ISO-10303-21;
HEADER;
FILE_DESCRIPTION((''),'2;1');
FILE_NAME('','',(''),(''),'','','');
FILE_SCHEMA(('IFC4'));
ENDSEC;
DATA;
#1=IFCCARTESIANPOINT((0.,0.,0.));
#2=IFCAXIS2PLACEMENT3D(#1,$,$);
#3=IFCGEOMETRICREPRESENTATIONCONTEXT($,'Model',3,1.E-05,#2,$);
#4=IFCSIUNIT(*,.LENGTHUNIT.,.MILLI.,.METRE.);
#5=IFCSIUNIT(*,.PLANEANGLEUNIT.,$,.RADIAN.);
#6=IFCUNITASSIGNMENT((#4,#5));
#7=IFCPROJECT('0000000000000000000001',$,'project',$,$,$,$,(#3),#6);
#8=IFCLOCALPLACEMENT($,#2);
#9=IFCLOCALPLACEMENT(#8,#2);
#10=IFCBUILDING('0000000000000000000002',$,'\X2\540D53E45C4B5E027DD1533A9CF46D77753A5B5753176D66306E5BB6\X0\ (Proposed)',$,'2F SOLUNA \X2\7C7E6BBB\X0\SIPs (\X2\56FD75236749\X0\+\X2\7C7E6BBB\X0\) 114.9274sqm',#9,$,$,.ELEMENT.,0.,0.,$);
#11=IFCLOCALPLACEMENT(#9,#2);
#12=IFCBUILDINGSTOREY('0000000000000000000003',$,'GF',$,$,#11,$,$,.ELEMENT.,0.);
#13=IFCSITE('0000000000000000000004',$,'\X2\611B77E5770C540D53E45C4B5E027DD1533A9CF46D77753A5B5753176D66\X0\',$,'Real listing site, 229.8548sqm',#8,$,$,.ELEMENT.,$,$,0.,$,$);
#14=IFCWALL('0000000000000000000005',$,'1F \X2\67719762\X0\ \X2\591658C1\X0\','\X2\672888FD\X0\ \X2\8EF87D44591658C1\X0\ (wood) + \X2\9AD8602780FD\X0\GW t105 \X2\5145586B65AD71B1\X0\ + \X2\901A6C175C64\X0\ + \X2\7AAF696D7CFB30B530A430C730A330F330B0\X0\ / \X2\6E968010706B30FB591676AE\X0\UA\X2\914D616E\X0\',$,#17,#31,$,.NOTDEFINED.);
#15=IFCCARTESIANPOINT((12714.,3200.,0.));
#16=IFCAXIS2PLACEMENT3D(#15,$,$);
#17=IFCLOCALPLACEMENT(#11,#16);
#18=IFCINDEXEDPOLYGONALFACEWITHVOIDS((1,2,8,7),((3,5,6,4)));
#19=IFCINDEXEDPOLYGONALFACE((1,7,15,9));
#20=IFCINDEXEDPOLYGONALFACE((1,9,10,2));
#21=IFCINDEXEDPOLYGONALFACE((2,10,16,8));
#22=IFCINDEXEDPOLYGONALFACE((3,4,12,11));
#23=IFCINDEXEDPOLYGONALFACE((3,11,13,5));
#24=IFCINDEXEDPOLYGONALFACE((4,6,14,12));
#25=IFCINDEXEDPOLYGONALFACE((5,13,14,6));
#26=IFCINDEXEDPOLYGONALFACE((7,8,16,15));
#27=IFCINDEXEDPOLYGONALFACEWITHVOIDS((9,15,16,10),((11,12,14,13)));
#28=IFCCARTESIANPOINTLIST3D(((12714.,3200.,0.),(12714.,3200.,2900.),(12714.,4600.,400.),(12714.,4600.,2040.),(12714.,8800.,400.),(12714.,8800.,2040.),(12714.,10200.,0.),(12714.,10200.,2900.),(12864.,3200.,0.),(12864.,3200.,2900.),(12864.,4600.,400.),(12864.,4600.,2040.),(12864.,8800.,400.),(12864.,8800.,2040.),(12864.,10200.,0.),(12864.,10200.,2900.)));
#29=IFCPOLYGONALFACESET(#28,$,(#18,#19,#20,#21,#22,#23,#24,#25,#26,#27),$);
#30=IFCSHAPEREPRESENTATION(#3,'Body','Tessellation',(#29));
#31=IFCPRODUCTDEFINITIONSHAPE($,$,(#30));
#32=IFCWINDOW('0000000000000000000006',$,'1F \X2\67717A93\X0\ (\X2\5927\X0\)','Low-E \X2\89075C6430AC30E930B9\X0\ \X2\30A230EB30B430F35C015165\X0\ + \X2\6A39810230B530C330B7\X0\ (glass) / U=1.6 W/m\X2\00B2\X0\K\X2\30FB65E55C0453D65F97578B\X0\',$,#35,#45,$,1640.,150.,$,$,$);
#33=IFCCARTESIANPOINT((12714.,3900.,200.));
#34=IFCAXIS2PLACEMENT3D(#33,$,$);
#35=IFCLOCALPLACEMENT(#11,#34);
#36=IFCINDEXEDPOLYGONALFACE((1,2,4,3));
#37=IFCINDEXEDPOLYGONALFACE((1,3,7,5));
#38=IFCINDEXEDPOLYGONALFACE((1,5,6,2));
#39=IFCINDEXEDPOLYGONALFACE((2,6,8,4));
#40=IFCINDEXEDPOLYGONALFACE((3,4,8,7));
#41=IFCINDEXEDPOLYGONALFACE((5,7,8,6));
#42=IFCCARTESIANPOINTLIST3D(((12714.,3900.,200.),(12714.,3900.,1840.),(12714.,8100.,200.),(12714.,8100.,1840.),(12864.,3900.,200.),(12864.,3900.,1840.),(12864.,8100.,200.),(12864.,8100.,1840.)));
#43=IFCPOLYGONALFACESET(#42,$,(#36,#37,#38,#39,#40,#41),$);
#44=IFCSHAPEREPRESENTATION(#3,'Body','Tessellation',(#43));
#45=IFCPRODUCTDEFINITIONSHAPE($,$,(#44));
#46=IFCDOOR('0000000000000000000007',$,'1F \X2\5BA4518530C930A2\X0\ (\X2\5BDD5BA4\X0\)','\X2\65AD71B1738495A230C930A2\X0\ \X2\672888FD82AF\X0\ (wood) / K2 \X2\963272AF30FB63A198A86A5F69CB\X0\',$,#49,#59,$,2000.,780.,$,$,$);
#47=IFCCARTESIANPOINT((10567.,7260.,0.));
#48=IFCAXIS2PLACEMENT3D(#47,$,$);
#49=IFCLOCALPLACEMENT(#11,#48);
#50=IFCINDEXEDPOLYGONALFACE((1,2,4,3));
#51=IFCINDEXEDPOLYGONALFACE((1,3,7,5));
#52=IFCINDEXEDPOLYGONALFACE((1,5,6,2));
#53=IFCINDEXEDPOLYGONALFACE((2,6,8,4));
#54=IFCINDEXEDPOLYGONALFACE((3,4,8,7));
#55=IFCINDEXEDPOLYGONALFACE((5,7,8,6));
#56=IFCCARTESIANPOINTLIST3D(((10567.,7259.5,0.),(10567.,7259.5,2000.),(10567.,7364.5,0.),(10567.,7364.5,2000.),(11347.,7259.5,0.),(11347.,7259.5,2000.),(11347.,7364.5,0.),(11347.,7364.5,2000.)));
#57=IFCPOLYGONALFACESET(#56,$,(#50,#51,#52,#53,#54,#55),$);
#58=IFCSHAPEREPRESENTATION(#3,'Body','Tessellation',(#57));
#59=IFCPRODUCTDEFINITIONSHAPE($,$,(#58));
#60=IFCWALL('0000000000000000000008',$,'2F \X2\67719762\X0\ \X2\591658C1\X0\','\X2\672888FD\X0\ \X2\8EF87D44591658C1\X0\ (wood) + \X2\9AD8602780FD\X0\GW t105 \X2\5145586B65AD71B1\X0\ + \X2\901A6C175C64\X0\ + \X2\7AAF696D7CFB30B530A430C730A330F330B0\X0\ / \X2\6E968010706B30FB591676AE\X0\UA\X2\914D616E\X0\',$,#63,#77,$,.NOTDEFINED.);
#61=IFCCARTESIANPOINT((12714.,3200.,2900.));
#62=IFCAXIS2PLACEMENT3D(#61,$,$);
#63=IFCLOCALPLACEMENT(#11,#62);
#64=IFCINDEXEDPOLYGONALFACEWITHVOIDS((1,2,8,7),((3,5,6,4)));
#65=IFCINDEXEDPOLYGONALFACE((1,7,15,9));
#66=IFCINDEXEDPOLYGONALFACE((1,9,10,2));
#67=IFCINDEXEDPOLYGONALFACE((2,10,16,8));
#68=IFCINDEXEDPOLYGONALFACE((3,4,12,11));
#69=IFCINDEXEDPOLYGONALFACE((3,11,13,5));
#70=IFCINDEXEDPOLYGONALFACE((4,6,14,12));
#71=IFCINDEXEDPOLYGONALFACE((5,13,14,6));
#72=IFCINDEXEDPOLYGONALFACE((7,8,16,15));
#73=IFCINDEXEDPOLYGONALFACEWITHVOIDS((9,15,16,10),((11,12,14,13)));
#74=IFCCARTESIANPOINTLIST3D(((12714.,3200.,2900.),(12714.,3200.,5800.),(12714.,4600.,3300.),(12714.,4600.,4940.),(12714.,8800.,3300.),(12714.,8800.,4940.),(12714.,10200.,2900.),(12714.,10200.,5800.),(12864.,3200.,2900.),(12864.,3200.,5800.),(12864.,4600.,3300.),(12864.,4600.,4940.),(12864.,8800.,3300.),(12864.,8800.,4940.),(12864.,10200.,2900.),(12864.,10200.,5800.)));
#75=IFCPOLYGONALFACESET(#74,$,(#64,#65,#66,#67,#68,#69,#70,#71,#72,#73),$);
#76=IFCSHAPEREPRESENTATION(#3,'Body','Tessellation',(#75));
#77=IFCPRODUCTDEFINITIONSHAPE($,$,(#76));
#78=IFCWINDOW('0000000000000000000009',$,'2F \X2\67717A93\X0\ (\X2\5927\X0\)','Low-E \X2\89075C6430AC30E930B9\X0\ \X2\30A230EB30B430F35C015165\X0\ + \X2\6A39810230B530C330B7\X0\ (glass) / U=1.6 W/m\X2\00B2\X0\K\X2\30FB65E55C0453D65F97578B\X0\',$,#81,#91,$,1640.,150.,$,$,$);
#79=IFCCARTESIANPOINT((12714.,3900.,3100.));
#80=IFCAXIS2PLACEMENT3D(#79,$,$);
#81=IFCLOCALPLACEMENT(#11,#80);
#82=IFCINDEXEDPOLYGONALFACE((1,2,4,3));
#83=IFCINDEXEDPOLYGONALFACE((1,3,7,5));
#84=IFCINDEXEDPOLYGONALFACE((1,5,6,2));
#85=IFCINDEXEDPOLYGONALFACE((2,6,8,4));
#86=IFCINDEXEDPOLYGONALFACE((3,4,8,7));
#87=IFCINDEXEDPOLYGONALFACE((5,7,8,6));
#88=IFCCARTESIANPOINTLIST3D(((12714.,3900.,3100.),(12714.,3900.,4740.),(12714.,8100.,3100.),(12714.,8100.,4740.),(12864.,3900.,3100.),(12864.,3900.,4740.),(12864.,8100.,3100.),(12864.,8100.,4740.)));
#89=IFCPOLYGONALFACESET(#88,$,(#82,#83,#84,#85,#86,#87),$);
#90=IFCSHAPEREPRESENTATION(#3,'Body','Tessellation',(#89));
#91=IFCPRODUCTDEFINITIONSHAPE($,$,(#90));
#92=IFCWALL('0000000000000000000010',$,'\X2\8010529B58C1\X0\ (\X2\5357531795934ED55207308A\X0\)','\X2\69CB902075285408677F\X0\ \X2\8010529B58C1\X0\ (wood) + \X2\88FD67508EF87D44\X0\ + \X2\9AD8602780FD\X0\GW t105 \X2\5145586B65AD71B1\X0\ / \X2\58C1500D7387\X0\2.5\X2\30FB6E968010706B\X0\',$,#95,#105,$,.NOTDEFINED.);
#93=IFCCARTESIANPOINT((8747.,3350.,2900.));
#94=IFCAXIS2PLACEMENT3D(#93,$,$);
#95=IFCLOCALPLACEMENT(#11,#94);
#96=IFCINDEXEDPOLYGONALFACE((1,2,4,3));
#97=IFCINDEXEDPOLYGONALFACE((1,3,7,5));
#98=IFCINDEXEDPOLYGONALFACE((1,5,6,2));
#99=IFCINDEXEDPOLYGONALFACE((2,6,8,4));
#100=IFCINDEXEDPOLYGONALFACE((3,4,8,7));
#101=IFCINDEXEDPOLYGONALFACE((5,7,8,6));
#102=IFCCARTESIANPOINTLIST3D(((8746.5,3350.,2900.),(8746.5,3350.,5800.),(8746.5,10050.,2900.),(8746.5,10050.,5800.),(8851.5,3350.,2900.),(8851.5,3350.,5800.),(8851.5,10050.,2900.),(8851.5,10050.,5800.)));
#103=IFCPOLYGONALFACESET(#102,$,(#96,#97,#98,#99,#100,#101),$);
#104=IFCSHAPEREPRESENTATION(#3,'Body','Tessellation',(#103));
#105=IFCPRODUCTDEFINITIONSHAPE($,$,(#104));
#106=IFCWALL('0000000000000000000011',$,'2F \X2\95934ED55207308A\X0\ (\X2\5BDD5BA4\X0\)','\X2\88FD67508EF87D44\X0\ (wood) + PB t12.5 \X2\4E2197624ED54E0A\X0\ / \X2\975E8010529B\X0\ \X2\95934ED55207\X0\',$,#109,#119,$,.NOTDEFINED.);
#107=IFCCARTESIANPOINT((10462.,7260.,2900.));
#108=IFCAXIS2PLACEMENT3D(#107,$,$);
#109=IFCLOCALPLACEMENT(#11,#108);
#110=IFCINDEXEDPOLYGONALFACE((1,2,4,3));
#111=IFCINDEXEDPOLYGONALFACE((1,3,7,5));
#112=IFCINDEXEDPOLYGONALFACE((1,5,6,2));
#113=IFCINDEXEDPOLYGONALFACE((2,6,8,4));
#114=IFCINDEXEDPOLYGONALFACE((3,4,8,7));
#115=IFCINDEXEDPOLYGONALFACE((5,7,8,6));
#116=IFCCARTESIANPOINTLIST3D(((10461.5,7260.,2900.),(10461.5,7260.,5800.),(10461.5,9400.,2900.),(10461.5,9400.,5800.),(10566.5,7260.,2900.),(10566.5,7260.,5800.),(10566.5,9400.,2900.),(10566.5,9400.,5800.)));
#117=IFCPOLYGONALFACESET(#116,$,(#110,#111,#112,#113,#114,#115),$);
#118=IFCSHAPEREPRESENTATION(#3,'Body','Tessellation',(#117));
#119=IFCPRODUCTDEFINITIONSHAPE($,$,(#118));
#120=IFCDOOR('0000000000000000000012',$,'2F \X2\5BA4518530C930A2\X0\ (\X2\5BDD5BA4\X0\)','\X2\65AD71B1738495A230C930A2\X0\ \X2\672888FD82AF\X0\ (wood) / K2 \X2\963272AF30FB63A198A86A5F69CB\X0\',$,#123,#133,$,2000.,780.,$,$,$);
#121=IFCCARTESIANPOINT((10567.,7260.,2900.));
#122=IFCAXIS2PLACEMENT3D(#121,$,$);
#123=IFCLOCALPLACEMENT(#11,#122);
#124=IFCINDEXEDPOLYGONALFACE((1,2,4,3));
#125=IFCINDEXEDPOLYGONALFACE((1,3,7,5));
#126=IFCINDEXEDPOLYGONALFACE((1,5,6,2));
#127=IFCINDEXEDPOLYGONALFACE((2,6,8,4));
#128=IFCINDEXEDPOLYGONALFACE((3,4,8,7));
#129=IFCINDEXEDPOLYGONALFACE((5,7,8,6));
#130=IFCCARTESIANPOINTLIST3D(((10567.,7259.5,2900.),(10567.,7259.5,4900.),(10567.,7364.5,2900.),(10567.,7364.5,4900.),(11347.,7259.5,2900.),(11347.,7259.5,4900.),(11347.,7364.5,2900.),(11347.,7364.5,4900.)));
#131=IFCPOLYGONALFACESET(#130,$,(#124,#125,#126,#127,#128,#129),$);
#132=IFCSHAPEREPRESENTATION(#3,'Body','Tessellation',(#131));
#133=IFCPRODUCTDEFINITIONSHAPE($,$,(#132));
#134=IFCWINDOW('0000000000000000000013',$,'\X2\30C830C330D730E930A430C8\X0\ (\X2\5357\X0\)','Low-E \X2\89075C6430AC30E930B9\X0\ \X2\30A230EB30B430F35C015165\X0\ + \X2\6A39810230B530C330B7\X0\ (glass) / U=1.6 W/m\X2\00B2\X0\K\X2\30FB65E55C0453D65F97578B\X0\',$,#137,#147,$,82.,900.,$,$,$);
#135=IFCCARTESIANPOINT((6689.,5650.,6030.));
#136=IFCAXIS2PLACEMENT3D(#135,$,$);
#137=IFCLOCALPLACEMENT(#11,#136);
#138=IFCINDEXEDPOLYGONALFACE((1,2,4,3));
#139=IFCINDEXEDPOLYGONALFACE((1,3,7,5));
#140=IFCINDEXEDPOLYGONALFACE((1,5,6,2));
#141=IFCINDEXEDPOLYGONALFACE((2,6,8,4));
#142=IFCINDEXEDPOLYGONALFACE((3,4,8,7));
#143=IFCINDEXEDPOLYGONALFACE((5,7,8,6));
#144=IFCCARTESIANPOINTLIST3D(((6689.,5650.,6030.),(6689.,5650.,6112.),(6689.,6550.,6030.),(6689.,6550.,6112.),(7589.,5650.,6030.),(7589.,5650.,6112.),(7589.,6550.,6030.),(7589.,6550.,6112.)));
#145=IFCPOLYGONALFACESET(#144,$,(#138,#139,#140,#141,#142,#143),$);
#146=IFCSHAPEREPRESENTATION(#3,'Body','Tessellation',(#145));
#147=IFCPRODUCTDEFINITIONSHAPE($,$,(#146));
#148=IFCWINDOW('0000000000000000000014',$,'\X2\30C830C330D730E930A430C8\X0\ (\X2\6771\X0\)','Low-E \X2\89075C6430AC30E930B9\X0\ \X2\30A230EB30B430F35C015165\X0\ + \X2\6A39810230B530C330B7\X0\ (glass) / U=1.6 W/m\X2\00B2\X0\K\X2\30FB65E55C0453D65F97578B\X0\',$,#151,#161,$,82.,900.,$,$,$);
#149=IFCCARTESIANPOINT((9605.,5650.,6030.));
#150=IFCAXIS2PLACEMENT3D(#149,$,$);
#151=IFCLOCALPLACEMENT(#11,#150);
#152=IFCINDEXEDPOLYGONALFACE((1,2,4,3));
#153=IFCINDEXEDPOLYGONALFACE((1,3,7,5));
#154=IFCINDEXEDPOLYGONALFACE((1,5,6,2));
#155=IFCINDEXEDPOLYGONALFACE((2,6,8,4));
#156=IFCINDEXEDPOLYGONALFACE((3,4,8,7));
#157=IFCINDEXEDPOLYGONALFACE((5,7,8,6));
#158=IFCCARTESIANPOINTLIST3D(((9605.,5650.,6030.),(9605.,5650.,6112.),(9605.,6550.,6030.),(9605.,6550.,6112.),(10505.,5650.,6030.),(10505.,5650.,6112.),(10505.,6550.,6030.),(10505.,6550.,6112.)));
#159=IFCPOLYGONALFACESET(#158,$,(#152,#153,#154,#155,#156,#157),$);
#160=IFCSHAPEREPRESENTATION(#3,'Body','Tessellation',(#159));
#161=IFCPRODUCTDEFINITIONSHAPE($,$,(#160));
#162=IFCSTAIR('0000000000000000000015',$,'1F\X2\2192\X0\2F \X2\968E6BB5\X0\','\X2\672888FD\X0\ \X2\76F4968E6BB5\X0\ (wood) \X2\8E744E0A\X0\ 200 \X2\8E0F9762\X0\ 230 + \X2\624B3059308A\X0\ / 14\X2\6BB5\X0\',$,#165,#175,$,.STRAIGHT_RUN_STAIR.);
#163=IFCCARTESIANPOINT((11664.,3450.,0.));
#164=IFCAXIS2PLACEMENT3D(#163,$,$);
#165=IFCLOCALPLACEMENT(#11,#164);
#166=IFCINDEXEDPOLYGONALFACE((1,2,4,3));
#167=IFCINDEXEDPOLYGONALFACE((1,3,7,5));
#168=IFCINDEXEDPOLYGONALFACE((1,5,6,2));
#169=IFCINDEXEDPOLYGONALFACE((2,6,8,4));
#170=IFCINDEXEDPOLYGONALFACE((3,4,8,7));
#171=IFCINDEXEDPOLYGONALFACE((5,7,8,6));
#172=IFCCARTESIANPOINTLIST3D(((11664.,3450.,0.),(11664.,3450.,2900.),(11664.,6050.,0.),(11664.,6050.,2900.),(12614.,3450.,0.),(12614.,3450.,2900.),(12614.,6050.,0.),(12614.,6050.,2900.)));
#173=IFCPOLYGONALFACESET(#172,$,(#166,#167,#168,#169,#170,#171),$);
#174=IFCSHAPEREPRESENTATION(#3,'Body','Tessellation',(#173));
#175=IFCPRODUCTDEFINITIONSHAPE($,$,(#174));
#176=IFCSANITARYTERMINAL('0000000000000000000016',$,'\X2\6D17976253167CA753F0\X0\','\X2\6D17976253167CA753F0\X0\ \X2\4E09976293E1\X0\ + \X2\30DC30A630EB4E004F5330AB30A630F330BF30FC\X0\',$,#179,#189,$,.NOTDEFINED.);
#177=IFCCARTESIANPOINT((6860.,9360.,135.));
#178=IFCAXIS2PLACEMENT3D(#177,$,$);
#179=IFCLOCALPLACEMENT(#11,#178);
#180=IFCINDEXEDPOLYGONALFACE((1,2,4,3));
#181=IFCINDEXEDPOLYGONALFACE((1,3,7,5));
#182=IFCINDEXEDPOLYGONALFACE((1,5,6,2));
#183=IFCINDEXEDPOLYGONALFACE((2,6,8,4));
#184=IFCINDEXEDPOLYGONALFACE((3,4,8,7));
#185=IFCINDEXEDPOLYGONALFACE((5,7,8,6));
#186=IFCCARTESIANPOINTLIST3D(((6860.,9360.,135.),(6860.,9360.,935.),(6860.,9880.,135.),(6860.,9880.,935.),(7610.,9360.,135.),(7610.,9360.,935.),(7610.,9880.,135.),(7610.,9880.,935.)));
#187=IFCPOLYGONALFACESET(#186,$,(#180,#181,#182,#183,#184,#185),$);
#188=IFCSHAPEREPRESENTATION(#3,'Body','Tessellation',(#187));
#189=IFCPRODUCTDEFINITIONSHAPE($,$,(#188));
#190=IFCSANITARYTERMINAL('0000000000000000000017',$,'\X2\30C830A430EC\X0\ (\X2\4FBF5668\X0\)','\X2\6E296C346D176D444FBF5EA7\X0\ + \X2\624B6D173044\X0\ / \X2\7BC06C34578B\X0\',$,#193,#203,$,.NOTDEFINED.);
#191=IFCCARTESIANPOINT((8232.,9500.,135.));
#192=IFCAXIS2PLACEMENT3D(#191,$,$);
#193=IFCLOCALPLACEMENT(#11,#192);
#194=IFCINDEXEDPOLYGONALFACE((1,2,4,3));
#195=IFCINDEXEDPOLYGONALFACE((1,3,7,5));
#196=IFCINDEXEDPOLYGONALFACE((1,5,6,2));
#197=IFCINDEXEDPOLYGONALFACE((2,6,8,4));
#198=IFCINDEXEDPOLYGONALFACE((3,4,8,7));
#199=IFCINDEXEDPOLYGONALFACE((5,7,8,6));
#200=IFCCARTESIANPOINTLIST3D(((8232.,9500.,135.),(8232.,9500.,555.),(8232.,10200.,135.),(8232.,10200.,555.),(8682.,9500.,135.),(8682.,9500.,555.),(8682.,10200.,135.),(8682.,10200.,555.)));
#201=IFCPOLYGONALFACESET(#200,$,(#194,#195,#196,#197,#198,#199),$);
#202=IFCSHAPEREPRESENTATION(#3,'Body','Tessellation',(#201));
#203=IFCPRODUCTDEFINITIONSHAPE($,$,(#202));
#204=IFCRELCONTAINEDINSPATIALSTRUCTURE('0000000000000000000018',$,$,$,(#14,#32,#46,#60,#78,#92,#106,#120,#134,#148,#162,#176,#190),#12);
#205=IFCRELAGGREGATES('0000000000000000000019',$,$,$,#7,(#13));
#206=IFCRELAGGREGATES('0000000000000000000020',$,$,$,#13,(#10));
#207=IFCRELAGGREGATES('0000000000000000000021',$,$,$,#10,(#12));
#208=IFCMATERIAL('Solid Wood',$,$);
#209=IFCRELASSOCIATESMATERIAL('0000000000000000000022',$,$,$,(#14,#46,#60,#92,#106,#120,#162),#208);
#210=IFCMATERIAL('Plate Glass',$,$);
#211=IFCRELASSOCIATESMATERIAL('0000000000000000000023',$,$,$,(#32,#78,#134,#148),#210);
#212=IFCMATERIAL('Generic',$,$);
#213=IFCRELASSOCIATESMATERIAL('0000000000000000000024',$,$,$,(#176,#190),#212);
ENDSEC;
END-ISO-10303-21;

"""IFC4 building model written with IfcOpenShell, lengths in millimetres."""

from ifc_helpers import new_model, si_unit, frame, frame_2d, origin, place, context, project, spatial, rectangle, extrude, material, element, fill, save


model = new_model("IFC4")

# Units and contexts
model_context = context("Model", 3, precision=1e-05, world=origin())
ifc_project = project(units=[si_unit("LENGTHUNIT", "METRE", prefix="MILLI"), si_unit("PLANEANGLEUNIT", "RADIAN")], contexts=[model_context])

# Site, building, storey
site_placement = place(None, origin())
site = spatial("IfcSite", under=ifc_project, at=site_placement, Name="愛知県名古屋市緑区鳴海町字北浦", ObjectType="Real listing site, 229.8548sqm", CompositionType="ELEMENT", RefElevation=0.0)
building_placement = place(site_placement, origin())
building = spatial("IfcBuilding", under=site, at=building_placement, Name="名古屋市緑区鳴海町字北浦の家 (Proposed)", ObjectType="2F SOLUNA 籾殻SIPs (国産杉+籾殻) 114.9274sqm", CompositionType="ELEMENT", ElevationOfRefHeight=0.0, ElevationOfTerrain=0.0)
storey_placement = place(building_placement, origin())
storey = spatial("IfcBuildingStorey", under=building, at=storey_placement, Name="GF", CompositionType="ELEMENT", Elevation=0.0)

# Wall, opening, window
ifc_material_1 = material(Name="Solid Wood")
wall_1_placement = place(storey_placement, frame((12714.0, 3200.0, 0.0)))
wall_1 = element("IfcWall", 1, at=wall_1_placement, inside=storey, material=ifc_material_1, Name="1F 東面 外壁", Description="木製 軸組外壁 (wood) + 高性能GW t105 充填断熱 + 通気層 + 窯業系サイディング / 準耐火・外皮UA配慮", PredefinedType="NOTDEFINED", context=model_context, shape_type="SweptSolid", body=[
    extrude(rectangle(XDim=150.0, YDim=7000.0, at=frame_2d((75.0, 3500.0))), frame((12714.0, 3200.0, 0.0)), (0.0, 0.0, 1.0), 2900.0),
])
opening_1_placement = place(storey_placement, frame((12714.0, 3900.0, 200.0)))
opening_1 = element("IfcOpeningElement", 2, at=opening_1_placement, cuts=wall_1, PredefinedType="NOTDEFINED", context=model_context, shape_type="SweptSolid", body=[
    extrude(rectangle(XDim=150.0, YDim=4200.0, at=frame_2d((75.0, 2100.0))), frame((12714.0, 3900.0, 200.0)), (0.0, 0.0, 1.0), 1640.0),
])
ifc_material_2 = material(Name="Plate Glass")
window_1_placement = place(storey_placement, frame((12714.0, 3900.0, 200.0)))
window_1 = element("IfcWindow", 3, at=window_1_placement, inside=storey, material=ifc_material_2, Name="1F 東窓 (大)", Description="Low-E 複層ガラス アルゴン封入 + 樹脂サッシ (glass) / U=1.6 W/m²K・日射取得型", OverallHeight=1640.0, OverallWidth=150.0, context=model_context, shape_type="SweptSolid", body=[
    extrude(rectangle(XDim=150.0, YDim=4200.0, at=frame_2d((75.0, 2100.0))), frame((12714.0, 3900.0, 200.0)), (0.0, 0.0, 1.0), 1640.0),
])
fill(opening_1, window_1)

# Door
door_1_placement = place(storey_placement, frame((10567.0, 7260.0, 0.0)))
element("IfcDoor", 4, at=door_1_placement, inside=storey, material=ifc_material_1, Name="1F 室内ドア (寝室)", Description="断熱玄関ドア 木製芯 (wood) / K2 防犯・採風機構", OverallHeight=2000.0, OverallWidth=780.0, context=model_context, shape_type="SweptSolid", body=[
    extrude(rectangle(XDim=780.0, YDim=105.0, at=frame_2d((390.0, 52.0))), frame((10567.0, 7260.0, 0.0)), (0.0, 0.0, 1.0), 2000.0),
])

# Wall, opening, window
wall_2_placement = place(storey_placement, frame((12714.0, 3200.0, 2900.0)))
wall_2 = element("IfcWall", 5, at=wall_2_placement, inside=storey, material=ifc_material_1, Name="2F 東面 外壁", Description="木製 軸組外壁 (wood) + 高性能GW t105 充填断熱 + 通気層 + 窯業系サイディング / 準耐火・外皮UA配慮", PredefinedType="NOTDEFINED", context=model_context, shape_type="SweptSolid", body=[
    extrude(rectangle(XDim=150.0, YDim=7000.0, at=frame_2d((75.0, 3500.0))), frame((12714.0, 3200.0, 2900.0)), (0.0, 0.0, 1.0), 2900.0),
])
opening_2_placement = place(storey_placement, frame((12714.0, 3900.0, 3100.0)))
opening_2 = element("IfcOpeningElement", 6, at=opening_2_placement, cuts=wall_2, PredefinedType="NOTDEFINED", context=model_context, shape_type="SweptSolid", body=[
    extrude(rectangle(XDim=150.0, YDim=4200.0, at=frame_2d((75.0, 2100.0))), frame((12714.0, 3900.0, 3100.0)), (0.0, 0.0, 1.0), 1640.0),
])
window_2_placement = place(storey_placement, frame((12714.0, 3900.0, 3100.0)))
window_2 = element("IfcWindow", 7, at=window_2_placement, inside=storey, material=ifc_material_2, Name="2F 東窓 (大)", Description="Low-E 複層ガラス アルゴン封入 + 樹脂サッシ (glass) / U=1.6 W/m²K・日射取得型", OverallHeight=1640.0, OverallWidth=150.0, context=model_context, shape_type="SweptSolid", body=[
    extrude(rectangle(XDim=150.0, YDim=4200.0, at=frame_2d((75.0, 2100.0))), frame((12714.0, 3900.0, 3100.0)), (0.0, 0.0, 1.0), 1640.0),
])
fill(opening_2, window_2)

# Walls
wall_3_placement = place(storey_placement, frame((8747.0, 3350.0, 2900.0)))
element("IfcWall", 8, at=wall_3_placement, inside=storey, material=ifc_material_1, Name="耐力壁 (南北間仕切り)", Description="構造用合板 耐力壁 (wood) + 製材軸組 + 高性能GW t105 充填断熱 / 壁倍率2.5・準耐火", PredefinedType="NOTDEFINED", context=model_context, shape_type="SweptSolid", body=[
    extrude(rectangle(XDim=105.0, YDim=6700.0, at=frame_2d((52.0, 3350.0))), frame((8747.0, 3350.0, 2900.0)), (0.0, 0.0, 1.0), 2900.0),
])
wall_4_placement = place(storey_placement, frame((10462.0, 7260.0, 2900.0)))
element("IfcWall", 9, at=wall_4_placement, inside=storey, material=ifc_material_1, Name="2F 間仕切り (寝室)", Description="製材軸組 (wood) + PB t12.5 両面仕上 / 非耐力 間仕切", PredefinedType="NOTDEFINED", context=model_context, shape_type="SweptSolid", body=[
    extrude(rectangle(XDim=105.0, YDim=2140.0, at=frame_2d((52.0, 1070.0))), frame((10462.0, 7260.0, 2900.0)), (0.0, 0.0, 1.0), 2900.0),
])

# Door
door_2_placement = place(storey_placement, frame((10567.0, 7260.0, 2900.0)))
element("IfcDoor", 10, at=door_2_placement, inside=storey, material=ifc_material_1, Name="2F 室内ドア (寝室)", Description="断熱玄関ドア 木製芯 (wood) / K2 防犯・採風機構", OverallHeight=2000.0, OverallWidth=780.0, context=model_context, shape_type="SweptSolid", body=[
    extrude(rectangle(XDim=780.0, YDim=105.0, at=frame_2d((390.0, 52.0))), frame((10567.0, 7260.0, 2900.0)), (0.0, 0.0, 1.0), 2000.0),
])

# Windows
window_3_placement = place(storey_placement, frame((6689.0, 5650.0, 6030.0)))
element("IfcWindow", 11, at=window_3_placement, inside=storey, material=ifc_material_2, Name="トップライト (南)", Description="Low-E 複層ガラス アルゴン封入 + 樹脂サッシ (glass) / U=1.6 W/m²K・日射取得型", OverallHeight=82.0, OverallWidth=900.0, context=model_context, shape_type="SweptSolid", body=[
    extrude(rectangle(XDim=900.0, YDim=900.0, at=frame_2d((450.0, 450.0))), frame((6689.0, 5650.0, 6030.0)), (0.0, 0.0, 1.0), 82.0),
])
window_4_placement = place(storey_placement, frame((9605.0, 5650.0, 6030.0)))
element("IfcWindow", 12, at=window_4_placement, inside=storey, material=ifc_material_2, Name="トップライト (東)", Description="Low-E 複層ガラス アルゴン封入 + 樹脂サッシ (glass) / U=1.6 W/m²K・日射取得型", OverallHeight=82.0, OverallWidth=900.0, context=model_context, shape_type="SweptSolid", body=[
    extrude(rectangle(XDim=900.0, YDim=900.0, at=frame_2d((450.0, 450.0))), frame((9605.0, 5650.0, 6030.0)), (0.0, 0.0, 1.0), 82.0),
])

# Stair
stair_placement = place(storey_placement, frame((11664.0, 3450.0, 0.0)))
element("IfcStair", 13, at=stair_placement, inside=storey, material=ifc_material_1, Name="1F→2F 階段", Description="木製 直階段 (wood) 蹴上 200 踏面 230 + 手すり / 14段", PredefinedType="STRAIGHT_RUN_STAIR", context=model_context, shape_type="SweptSolid", body=[
    extrude(rectangle(XDim=950.0, YDim=2600.0, at=frame_2d((475.0, 1300.0))), frame((11664.0, 3450.0, 0.0)), (0.0, 0.0, 1.0), 2900.0),
])

# Sanitary terminals
ifc_material_3 = material(Name="Generic")
sanitary_terminal_1_placement = place(storey_placement, frame((6860.0, 9360.0, 135.0)))
element("IfcSanitaryTerminal", 14, at=sanitary_terminal_1_placement, inside=storey, material=ifc_material_3, Name="洗面化粧台", Description="洗面化粧台 三面鏡 + ボウル一体カウンター", PredefinedType="NOTDEFINED", context=model_context, shape_type="SweptSolid", body=[
    extrude(rectangle(XDim=750.0, YDim=520.0, at=frame_2d((375.0, 260.0))), frame((6860.0, 9360.0, 135.0)), (0.0, 0.0, 1.0), 800.0),
])
sanitary_terminal_2_placement = place(storey_placement, frame((8232.0, 9500.0, 135.0)))
element("IfcSanitaryTerminal", 15, at=sanitary_terminal_2_placement, inside=storey, material=ifc_material_3, Name="トイレ (便器)", Description="温水洗浄便座 + 手洗い / 節水型", PredefinedType="NOTDEFINED", context=model_context, shape_type="SweptSolid", body=[
    extrude(rectangle(XDim=450.0, YDim=700.0, at=frame_2d((225.0, 350.0))), frame((8232.0, 9500.0, 135.0)), (0.0, 0.0, 1.0), 420.0),
])

save(model, "model.ifc")
